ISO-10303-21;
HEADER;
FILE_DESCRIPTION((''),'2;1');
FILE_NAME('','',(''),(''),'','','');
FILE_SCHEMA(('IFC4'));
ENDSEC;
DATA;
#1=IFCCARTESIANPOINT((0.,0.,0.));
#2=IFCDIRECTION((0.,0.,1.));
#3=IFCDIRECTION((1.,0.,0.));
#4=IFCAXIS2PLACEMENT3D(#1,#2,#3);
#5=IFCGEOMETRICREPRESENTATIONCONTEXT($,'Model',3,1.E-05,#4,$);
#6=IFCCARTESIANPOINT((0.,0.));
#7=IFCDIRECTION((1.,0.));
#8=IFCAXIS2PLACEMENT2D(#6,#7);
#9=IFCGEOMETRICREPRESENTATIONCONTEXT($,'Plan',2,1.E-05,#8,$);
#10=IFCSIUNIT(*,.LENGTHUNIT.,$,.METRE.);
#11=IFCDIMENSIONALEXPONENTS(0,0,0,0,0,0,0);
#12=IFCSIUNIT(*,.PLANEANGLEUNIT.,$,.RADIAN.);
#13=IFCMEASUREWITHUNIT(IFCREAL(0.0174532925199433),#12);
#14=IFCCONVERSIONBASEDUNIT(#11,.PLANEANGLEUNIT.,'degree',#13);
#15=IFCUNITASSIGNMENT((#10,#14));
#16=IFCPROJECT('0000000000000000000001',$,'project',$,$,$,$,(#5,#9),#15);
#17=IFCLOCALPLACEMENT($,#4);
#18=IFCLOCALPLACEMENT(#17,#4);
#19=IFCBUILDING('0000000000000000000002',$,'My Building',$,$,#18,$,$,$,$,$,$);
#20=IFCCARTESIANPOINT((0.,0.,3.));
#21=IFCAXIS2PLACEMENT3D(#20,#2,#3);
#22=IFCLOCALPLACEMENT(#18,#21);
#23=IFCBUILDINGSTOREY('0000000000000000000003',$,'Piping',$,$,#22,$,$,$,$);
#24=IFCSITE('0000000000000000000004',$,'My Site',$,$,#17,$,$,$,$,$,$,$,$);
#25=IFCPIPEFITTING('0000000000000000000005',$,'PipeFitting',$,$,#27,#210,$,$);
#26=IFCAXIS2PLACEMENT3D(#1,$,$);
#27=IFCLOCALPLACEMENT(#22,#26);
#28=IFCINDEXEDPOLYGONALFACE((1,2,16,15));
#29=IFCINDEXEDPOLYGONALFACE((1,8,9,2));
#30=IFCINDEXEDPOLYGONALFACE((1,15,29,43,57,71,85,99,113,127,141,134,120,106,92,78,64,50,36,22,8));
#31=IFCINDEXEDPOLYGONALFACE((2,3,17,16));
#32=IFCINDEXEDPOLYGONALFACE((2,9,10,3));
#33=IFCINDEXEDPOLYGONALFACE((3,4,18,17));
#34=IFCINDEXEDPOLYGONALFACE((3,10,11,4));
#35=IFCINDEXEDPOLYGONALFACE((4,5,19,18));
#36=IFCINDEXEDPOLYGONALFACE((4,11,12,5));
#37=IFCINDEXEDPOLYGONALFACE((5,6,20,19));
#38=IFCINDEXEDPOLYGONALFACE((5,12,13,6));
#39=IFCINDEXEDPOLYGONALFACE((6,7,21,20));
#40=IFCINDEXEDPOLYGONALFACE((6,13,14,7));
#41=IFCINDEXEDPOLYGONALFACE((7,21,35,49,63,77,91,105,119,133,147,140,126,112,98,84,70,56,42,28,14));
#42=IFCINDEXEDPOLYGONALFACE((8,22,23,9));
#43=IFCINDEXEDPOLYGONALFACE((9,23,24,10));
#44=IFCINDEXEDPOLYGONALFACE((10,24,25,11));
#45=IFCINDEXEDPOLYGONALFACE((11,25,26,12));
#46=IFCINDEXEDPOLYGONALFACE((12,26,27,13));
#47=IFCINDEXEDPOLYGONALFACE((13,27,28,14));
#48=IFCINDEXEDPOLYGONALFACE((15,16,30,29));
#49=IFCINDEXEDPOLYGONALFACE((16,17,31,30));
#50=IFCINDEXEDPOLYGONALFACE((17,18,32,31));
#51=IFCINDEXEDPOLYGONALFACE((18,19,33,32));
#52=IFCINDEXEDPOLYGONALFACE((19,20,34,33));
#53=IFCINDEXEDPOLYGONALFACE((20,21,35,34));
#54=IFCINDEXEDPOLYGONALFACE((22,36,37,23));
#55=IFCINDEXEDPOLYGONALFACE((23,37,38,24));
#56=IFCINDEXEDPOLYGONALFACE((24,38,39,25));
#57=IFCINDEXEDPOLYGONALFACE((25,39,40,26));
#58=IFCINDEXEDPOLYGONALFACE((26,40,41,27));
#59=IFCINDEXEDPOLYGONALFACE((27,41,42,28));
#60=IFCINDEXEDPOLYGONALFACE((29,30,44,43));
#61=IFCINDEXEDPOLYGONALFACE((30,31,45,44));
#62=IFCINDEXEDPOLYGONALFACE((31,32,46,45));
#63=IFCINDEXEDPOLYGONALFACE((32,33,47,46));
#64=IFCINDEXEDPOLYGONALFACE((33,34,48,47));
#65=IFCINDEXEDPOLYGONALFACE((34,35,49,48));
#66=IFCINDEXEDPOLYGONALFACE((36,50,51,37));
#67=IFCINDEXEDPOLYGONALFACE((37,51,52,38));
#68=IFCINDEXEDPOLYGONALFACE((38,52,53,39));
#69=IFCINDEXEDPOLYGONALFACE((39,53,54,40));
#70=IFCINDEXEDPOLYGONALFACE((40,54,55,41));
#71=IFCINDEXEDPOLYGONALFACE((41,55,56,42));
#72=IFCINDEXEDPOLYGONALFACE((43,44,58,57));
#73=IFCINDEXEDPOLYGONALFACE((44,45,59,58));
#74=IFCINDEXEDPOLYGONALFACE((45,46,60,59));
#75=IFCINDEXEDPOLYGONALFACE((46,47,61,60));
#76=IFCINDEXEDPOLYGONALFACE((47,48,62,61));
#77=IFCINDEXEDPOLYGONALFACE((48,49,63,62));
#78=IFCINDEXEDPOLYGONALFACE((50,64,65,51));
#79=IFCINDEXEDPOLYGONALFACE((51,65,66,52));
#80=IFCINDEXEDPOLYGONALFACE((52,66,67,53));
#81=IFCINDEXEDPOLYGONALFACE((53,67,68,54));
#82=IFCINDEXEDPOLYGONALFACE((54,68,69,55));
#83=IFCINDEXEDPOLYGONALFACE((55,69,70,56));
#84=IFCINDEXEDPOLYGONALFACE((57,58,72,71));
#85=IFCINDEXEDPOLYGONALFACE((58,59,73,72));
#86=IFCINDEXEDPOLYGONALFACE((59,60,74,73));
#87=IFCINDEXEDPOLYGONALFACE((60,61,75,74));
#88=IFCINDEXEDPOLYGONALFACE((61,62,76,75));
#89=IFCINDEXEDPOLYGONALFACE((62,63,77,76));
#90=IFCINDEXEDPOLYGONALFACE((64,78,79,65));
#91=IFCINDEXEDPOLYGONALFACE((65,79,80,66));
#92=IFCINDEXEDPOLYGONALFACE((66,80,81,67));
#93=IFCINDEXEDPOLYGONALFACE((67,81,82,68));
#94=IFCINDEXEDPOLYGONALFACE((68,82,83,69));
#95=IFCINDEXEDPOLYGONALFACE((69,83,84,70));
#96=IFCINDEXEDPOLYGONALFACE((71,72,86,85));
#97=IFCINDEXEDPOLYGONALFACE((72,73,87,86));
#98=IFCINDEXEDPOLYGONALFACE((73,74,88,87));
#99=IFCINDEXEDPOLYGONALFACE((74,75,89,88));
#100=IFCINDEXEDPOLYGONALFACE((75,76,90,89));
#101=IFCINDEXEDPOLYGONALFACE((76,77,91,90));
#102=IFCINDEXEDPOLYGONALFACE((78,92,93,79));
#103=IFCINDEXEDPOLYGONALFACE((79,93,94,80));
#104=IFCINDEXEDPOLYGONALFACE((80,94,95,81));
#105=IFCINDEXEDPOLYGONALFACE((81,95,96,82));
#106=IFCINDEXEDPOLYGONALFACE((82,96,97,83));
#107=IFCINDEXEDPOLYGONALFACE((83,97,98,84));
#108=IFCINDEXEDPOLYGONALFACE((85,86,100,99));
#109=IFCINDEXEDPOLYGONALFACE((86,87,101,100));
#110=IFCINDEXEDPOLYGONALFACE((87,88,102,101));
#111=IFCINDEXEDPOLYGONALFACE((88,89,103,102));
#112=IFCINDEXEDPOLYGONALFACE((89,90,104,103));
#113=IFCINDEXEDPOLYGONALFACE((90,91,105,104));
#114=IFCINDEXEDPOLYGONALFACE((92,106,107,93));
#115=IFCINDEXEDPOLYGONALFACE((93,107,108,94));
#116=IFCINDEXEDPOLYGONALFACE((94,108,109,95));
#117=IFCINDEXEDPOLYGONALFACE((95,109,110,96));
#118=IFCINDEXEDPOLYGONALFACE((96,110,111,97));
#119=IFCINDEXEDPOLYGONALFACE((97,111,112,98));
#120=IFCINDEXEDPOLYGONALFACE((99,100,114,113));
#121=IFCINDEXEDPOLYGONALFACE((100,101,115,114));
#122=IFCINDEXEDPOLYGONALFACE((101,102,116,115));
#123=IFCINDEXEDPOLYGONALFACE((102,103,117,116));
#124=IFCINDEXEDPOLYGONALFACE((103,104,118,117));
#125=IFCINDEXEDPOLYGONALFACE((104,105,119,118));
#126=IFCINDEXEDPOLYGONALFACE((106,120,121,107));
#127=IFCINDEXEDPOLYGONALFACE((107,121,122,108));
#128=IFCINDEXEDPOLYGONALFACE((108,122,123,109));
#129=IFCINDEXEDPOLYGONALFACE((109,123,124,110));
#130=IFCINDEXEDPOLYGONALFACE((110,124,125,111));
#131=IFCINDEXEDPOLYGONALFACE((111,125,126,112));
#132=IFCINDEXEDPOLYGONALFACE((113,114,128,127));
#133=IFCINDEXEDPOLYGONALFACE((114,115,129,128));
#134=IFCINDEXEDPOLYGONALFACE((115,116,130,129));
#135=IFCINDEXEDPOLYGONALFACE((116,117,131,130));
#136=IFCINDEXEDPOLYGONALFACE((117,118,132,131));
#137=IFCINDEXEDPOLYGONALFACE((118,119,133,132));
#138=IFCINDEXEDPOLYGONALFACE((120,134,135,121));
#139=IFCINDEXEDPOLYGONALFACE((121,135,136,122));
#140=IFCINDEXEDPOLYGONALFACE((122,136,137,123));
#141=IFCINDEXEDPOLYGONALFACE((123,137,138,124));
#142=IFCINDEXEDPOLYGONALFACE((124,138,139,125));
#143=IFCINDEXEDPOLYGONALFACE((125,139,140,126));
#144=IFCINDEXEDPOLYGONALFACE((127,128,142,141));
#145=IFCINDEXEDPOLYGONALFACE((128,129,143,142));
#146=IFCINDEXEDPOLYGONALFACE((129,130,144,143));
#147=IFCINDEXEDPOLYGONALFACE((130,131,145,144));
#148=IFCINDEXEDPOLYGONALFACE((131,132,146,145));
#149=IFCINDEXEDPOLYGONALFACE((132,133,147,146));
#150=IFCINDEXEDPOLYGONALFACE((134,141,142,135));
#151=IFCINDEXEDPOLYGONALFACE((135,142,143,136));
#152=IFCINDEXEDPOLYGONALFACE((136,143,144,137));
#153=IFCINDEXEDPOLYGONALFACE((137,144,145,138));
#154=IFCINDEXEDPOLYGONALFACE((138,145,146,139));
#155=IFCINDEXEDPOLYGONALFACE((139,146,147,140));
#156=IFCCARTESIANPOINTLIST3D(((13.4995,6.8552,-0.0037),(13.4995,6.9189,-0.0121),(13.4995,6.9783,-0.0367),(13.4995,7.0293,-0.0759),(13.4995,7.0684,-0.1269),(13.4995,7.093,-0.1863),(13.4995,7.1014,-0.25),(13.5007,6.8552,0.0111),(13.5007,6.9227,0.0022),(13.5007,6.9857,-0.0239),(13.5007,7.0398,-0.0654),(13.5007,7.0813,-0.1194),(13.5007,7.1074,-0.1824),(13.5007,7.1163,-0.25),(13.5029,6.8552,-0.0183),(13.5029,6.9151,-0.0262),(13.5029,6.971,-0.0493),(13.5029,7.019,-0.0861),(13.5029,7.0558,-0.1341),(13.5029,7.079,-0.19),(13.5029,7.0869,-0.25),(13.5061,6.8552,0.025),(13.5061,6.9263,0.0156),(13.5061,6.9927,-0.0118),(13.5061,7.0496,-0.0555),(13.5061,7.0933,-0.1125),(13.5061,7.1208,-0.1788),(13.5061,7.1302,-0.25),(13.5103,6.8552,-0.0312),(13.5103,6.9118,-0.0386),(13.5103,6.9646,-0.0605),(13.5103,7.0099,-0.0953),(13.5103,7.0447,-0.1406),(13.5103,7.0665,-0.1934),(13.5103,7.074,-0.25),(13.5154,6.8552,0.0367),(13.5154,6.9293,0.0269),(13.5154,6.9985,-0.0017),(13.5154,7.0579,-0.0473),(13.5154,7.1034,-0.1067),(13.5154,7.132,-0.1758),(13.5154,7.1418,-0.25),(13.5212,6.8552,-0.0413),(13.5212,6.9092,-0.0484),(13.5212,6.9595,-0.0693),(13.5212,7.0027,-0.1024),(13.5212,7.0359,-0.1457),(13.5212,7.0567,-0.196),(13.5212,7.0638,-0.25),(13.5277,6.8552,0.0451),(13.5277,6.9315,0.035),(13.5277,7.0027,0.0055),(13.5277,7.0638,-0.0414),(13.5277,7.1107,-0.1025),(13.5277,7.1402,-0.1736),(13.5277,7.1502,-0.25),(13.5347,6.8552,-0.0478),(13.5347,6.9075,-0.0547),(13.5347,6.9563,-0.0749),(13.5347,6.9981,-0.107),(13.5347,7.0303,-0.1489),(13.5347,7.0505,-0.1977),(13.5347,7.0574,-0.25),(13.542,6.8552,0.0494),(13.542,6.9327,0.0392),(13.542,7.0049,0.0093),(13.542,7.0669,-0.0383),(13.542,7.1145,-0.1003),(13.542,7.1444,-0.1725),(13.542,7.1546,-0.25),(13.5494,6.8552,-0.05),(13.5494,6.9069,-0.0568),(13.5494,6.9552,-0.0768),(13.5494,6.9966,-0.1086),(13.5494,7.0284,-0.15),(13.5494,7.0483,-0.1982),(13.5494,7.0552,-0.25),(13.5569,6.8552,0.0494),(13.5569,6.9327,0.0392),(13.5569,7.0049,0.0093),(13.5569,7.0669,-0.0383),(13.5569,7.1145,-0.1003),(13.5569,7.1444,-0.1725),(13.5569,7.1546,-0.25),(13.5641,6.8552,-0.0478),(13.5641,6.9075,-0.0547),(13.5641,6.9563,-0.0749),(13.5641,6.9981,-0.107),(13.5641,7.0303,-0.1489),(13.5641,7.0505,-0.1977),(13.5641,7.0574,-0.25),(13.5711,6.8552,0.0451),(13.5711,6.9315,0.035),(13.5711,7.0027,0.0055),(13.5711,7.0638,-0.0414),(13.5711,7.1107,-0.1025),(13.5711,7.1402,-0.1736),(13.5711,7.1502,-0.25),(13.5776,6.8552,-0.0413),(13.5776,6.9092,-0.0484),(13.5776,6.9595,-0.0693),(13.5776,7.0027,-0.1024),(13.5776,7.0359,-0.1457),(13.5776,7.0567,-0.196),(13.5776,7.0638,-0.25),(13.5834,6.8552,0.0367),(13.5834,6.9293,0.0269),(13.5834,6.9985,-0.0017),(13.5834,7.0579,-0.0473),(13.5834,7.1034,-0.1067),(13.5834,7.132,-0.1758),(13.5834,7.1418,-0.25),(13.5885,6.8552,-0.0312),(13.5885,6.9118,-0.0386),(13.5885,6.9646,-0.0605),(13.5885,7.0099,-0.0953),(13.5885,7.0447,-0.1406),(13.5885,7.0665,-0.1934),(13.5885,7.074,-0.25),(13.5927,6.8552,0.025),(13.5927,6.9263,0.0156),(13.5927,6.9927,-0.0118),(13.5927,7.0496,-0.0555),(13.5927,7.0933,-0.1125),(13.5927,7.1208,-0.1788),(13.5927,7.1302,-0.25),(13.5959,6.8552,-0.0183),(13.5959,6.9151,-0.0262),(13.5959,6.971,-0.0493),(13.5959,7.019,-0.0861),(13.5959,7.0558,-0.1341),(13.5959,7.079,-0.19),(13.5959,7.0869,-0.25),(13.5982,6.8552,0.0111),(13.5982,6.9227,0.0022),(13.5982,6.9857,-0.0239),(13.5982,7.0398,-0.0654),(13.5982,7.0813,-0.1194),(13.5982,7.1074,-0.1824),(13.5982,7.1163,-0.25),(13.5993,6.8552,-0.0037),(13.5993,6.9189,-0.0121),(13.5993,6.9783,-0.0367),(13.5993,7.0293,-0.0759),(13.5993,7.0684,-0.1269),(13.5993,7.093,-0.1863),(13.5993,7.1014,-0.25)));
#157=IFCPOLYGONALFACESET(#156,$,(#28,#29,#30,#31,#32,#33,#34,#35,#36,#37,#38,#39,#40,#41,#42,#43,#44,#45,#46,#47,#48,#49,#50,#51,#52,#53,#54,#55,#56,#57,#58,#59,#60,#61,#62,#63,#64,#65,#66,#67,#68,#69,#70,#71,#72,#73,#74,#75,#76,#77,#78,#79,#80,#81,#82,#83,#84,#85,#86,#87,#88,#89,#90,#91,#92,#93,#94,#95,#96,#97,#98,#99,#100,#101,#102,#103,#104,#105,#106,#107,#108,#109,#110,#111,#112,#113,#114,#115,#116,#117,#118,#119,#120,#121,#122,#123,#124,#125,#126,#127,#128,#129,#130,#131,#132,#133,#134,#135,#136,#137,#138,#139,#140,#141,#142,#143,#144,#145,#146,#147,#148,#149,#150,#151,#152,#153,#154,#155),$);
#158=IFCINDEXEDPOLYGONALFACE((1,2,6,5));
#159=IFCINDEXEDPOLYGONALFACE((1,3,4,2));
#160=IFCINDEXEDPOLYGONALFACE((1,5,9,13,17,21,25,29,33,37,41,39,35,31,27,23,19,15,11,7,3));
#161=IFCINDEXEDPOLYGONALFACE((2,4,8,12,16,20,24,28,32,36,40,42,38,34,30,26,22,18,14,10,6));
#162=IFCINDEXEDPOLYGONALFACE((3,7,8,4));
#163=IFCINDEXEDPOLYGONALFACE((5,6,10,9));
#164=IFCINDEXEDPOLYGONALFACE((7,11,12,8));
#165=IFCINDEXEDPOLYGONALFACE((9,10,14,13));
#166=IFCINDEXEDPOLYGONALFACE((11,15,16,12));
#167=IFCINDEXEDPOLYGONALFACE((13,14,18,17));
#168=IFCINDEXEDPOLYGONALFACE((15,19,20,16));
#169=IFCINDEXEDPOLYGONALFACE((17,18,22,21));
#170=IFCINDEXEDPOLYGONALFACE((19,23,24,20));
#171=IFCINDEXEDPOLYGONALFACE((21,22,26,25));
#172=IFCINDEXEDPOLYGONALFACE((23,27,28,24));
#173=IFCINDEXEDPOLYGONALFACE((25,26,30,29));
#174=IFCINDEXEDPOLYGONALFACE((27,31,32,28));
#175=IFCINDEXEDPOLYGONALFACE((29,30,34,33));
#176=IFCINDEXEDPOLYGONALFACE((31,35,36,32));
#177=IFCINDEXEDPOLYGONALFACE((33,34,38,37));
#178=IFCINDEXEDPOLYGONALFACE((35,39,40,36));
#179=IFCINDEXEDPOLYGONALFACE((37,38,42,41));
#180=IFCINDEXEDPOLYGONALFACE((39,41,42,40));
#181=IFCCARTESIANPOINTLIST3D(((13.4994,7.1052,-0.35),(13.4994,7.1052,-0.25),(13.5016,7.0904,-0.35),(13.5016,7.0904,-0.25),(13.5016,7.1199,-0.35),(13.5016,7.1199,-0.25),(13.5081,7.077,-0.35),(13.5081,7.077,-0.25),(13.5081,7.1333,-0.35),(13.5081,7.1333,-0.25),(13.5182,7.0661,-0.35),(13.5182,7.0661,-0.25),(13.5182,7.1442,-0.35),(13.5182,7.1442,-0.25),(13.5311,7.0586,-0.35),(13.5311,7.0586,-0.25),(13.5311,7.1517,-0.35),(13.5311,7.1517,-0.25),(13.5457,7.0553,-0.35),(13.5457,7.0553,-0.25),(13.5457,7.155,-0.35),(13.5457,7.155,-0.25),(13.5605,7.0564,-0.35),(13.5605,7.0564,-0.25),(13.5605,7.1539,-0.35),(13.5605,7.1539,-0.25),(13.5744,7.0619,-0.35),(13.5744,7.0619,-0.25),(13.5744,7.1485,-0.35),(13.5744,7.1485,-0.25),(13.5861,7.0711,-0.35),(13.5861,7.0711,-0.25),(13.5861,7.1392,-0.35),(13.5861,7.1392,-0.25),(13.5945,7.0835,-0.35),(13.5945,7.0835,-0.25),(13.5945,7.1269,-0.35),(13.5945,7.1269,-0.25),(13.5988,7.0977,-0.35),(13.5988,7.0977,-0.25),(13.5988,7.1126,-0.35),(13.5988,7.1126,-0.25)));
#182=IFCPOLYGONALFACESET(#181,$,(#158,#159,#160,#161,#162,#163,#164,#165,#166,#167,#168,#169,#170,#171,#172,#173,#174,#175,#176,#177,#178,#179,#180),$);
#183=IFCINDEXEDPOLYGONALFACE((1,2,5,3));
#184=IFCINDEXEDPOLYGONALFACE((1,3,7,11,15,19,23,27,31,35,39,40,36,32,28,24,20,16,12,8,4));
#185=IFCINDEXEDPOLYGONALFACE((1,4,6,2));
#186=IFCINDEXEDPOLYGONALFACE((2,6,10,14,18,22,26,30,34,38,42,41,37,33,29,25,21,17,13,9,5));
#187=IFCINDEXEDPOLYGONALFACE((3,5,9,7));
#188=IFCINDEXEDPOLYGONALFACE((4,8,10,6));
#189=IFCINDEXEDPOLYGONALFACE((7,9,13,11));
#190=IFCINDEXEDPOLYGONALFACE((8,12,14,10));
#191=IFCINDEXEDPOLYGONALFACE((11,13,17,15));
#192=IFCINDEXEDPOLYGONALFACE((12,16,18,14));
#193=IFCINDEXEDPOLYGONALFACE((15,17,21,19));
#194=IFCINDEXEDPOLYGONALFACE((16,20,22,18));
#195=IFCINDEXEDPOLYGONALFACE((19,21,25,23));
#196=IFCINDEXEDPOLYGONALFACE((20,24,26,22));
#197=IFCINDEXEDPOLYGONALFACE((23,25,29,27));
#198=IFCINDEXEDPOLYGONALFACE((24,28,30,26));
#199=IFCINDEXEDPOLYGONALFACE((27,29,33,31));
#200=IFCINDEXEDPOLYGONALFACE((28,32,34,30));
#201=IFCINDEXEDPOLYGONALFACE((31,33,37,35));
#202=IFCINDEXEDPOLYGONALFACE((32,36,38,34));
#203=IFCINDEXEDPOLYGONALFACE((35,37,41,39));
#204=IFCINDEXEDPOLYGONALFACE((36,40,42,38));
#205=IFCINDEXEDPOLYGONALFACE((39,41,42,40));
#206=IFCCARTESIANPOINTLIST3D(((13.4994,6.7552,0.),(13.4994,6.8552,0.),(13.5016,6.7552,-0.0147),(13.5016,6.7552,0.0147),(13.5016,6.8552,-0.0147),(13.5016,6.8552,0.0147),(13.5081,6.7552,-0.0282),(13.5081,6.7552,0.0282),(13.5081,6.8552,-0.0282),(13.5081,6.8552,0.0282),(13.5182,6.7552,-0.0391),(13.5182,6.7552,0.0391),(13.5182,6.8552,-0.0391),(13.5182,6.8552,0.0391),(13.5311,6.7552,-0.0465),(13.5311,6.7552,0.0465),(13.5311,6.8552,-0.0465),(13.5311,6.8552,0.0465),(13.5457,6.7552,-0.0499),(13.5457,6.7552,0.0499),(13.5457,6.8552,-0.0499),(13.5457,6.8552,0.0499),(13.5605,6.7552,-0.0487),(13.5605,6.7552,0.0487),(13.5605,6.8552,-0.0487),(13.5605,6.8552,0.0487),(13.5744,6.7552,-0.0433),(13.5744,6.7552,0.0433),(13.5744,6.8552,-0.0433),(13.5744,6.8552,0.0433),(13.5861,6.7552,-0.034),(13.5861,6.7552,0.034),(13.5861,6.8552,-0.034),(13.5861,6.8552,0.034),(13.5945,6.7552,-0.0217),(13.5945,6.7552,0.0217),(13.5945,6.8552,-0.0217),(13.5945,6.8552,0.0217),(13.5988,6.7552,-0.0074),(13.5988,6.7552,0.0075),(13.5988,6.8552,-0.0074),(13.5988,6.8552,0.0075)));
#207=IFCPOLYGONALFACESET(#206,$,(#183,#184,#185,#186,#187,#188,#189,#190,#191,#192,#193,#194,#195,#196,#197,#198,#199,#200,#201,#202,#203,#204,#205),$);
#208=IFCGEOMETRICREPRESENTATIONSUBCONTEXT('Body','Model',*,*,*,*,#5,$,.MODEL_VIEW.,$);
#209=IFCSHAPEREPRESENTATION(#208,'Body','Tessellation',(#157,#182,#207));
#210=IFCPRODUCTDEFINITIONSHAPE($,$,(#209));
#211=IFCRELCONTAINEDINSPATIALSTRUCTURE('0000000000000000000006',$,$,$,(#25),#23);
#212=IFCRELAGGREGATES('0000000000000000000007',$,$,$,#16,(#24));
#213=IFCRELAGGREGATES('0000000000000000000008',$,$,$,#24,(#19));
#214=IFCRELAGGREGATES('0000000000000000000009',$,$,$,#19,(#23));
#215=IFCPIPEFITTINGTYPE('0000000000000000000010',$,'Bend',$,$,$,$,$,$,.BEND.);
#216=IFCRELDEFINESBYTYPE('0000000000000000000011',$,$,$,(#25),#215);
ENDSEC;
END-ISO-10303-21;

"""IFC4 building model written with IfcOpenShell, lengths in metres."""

from ifc_helpers import new_model, entity, si_unit, converted_unit, frame, origin_with_axes, origin_2d_with_axis, place, context, subcontext, project, spatial, circle, extrude, source, transform, mapped, type_object, type_shapes, element, save


model = new_model("IFC4")

# Units and contexts
model_context = context("Model", 3, precision=1e-05, world=origin_with_axes())
plan_context = context("Plan", 2, precision=1e-05, world=origin_2d_with_axis())
body_context = subcontext(model_context, "Body", "Model", "MODEL_VIEW")
ifc_project = project(units=[si_unit("LENGTHUNIT", "METRE"), converted_unit("PLANEANGLEUNIT", "degree", entity("IfcReal", 0.0174532925199433), si_unit("PLANEANGLEUNIT", "RADIAN"), dimensions=[0, 0, 0, 0, 0, 0, 0])], contexts=[model_context, plan_context])

# Site, building, storey
site_placement = place(None, origin_with_axes())
site = spatial("IfcSite", under=ifc_project, at=site_placement, Name="My Site")
building_placement = place(site_placement, origin_with_axes())
building = spatial("IfcBuilding", under=site, at=building_placement, Name="My Building")
storey_placement = place(building_placement, frame((0.0, 0.0, 3.0), z_axis=(0.0, 0.0, 1.0), x_axis=(1.0, 0.0, 0.0)))
storey = spatial("IfcBuildingStorey", under=building, at=storey_placement, Name="Piping")

# Shared definitions
pipe_fitting_type = type_object("IfcPipeFittingType", Name="Bend", PredefinedType="BEND")
shared_shape = source(origin_with_axes(), body_context, "Body", "SolidModel", [
    entity("IfcSweptDiskSolid", entity("IfcIndexedPolyCurve", entity("IfcCartesianPointList3D", [[0.0, 0.0, -0.1], [0.0, -0.0732, -0.2768], [0.0, -0.25, -0.35]]), [entity("IfcArcIndex", [1, 2, 3])]), 0.05),
    extrude(circle(Radius=0.05), origin_with_axes(), (0.0, 0.0, -1.0), 0.1),
    extrude(circle(Radius=0.05), frame((0.0, -0.25, -0.35), z_axis=(0.0, -1.0, 0.0), x_axis=(1.0, 0.0, 0.0)), (0.0, 0.0, 1.0), 0.1),
])
type_shapes(pipe_fitting_type, [shared_shape])

# Pipe fitting
for number, where, z_axis, x_axis, name in (
    (1, (13.5494, 7.1052, -0.35), (0.0, 0.0, -1.0), (-1.0, 0.0, 0.0), "PipeFitting"),
):
    element("IfcPipeFitting", number, at=place(storey_placement, frame(where, z_axis=z_axis, x_axis=x_axis)), inside=storey, type_object=pipe_fitting_type, Name=name, context=body_context, shape_type="MappedRepresentation", body=[
        mapped(shared_shape, transform((0.0, 0.0, 0.0), x_axis=(1.0, 0.0, 0.0), y_axis=(0.0, 1.0, 0.0), z_axis=(0.0, 0.0, 1.0), scale=1.0)),
    ])

save(model, "model.ifc")
